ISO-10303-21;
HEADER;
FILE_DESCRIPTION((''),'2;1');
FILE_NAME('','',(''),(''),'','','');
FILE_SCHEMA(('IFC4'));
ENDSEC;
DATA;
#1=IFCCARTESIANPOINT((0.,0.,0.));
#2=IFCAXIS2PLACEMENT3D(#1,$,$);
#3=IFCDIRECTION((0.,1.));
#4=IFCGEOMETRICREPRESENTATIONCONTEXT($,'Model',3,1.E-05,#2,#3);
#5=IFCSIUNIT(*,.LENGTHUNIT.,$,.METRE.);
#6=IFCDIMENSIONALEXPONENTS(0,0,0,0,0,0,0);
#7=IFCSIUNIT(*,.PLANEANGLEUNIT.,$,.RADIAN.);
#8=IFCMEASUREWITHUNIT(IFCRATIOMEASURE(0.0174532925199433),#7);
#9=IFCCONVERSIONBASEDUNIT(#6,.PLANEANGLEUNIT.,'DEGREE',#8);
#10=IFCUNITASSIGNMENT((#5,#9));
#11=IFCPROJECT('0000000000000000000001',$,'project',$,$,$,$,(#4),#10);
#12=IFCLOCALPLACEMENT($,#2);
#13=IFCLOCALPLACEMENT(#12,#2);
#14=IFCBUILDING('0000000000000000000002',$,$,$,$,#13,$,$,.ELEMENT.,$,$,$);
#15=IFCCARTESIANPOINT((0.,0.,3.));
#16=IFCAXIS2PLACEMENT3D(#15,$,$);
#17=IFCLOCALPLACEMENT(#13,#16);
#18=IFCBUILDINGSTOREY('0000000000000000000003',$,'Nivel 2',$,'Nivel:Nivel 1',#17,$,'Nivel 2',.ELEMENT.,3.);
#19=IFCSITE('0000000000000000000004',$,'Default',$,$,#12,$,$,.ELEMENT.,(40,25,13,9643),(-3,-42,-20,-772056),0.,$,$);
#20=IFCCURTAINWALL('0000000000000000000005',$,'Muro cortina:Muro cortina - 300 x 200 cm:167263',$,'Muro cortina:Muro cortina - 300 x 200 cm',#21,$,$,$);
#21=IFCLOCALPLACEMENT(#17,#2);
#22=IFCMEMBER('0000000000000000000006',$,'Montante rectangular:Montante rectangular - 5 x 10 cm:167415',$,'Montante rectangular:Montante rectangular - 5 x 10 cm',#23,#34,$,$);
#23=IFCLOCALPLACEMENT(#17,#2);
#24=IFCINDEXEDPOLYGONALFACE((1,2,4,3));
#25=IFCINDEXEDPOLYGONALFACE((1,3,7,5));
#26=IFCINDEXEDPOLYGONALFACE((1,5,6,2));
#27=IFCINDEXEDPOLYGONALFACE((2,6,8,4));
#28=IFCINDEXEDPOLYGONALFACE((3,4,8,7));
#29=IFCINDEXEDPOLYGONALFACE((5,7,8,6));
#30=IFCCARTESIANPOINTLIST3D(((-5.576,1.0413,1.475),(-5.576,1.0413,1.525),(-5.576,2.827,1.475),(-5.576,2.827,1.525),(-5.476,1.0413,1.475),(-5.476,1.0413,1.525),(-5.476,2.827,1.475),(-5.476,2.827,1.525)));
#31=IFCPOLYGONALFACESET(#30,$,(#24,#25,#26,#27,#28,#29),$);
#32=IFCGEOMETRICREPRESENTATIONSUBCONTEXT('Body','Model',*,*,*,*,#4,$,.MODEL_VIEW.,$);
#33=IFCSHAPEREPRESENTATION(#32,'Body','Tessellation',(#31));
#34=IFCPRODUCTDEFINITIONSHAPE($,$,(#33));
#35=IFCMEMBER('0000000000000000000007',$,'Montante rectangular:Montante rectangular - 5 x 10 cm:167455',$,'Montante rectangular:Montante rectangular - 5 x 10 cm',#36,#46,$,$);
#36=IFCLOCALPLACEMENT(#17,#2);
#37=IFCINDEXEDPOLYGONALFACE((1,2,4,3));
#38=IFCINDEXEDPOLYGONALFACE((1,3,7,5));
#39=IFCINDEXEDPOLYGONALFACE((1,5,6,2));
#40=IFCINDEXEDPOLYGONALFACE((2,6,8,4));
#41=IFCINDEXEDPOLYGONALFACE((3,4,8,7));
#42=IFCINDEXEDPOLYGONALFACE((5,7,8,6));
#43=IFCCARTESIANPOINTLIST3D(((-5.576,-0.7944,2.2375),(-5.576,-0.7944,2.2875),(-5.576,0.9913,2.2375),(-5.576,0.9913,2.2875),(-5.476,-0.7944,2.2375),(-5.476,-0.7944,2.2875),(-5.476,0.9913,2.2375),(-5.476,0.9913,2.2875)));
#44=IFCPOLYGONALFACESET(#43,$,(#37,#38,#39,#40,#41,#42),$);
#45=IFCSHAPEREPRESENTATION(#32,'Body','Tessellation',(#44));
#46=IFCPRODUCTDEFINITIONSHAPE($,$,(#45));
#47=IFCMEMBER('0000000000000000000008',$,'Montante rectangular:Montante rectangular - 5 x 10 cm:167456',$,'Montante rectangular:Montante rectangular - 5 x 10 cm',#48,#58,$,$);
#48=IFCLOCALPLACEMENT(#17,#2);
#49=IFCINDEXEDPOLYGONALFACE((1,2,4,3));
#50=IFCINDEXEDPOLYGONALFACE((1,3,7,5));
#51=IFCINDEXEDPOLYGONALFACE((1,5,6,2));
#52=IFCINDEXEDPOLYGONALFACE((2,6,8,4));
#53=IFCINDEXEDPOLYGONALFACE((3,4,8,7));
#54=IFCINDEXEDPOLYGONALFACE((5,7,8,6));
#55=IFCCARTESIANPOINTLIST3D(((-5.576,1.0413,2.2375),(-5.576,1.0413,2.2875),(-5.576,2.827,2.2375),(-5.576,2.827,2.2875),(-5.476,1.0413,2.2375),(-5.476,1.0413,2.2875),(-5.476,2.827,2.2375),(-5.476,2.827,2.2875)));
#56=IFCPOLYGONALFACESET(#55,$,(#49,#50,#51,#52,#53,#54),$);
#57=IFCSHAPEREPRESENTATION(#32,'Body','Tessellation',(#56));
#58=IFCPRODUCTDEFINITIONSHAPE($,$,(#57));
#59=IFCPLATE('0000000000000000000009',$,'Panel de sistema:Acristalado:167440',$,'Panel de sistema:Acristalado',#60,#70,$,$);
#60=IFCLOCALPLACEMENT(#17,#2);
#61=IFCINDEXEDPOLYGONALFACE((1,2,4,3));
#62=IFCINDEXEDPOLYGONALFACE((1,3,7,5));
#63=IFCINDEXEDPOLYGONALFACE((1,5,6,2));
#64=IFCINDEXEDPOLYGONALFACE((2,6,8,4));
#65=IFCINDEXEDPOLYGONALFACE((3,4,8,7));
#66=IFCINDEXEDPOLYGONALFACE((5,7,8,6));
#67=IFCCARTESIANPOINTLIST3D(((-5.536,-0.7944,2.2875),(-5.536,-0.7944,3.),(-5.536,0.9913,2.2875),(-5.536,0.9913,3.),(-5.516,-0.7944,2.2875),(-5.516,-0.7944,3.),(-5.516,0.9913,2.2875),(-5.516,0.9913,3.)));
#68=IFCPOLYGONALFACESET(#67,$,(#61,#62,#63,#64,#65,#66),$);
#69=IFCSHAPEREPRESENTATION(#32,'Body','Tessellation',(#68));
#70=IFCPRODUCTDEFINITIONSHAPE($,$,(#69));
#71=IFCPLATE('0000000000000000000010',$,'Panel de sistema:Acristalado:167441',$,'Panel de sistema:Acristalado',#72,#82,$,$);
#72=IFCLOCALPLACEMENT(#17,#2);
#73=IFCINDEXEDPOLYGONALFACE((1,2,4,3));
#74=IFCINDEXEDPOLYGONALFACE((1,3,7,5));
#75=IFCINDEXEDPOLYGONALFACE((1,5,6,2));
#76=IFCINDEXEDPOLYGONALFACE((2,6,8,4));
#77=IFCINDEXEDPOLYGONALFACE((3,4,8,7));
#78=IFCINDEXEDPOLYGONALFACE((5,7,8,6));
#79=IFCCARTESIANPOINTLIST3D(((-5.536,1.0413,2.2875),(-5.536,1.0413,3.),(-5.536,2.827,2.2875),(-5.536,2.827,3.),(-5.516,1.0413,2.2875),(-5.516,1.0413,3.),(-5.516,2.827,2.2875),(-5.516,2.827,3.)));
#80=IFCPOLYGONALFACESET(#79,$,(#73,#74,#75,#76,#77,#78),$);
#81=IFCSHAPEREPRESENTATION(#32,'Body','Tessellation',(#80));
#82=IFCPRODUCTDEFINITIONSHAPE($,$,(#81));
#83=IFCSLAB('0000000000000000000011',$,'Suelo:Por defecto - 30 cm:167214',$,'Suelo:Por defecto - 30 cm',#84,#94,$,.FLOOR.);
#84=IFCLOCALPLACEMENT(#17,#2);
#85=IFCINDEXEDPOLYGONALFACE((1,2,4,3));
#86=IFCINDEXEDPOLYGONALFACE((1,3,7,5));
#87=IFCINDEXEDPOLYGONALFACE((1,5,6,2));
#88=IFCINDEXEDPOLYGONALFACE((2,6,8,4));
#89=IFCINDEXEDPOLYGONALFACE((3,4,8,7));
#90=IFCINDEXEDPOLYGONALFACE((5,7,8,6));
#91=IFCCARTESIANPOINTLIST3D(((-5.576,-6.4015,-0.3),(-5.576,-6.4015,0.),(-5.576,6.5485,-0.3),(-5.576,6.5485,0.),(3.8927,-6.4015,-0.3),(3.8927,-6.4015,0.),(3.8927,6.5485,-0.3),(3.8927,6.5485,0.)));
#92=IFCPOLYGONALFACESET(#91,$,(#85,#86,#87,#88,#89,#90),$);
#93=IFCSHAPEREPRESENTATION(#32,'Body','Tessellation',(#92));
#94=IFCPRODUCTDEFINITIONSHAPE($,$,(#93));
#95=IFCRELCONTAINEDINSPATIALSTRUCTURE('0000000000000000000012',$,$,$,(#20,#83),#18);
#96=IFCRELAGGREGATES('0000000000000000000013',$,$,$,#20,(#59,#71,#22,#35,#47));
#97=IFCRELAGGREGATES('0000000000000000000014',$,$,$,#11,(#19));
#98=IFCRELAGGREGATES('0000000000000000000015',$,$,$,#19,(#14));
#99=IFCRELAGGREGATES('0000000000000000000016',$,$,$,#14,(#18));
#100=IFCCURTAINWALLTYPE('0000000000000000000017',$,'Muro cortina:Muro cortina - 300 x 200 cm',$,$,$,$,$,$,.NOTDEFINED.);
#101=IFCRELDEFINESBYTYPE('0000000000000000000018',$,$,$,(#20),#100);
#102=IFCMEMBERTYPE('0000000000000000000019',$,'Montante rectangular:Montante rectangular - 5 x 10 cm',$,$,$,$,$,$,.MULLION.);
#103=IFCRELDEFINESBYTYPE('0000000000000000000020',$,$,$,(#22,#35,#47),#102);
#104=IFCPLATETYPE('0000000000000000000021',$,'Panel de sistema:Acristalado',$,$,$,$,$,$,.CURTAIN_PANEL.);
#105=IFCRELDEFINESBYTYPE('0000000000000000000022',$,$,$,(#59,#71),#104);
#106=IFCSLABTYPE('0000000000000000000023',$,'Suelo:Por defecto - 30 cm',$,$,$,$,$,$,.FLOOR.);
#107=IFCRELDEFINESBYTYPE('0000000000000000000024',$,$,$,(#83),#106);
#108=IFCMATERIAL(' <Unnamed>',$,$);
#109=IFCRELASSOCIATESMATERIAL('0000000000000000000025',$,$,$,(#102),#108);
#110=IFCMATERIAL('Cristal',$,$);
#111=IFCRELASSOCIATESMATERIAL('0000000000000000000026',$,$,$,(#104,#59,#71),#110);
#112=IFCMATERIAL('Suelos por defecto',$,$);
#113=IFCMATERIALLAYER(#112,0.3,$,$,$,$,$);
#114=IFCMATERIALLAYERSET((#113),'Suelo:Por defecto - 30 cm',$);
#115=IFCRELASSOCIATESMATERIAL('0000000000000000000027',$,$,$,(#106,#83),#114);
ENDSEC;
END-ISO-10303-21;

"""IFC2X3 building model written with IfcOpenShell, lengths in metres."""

from ifc_helpers import new_model, entity, si_unit, converted_unit, direction, frame, origin, origin_2d_with_axis, place, context, subcontext, project, spatial, rectangle, extrude, source, transform, mapped, material, layer, layer_set, layer_usage, type_object, type_shapes, element, aggregate, save


model = new_model("IFC2X3")

# Units and contexts
model_context = context("Model", 3, precision=1e-05, world=origin(), true_north=direction((0.0, 1.0)))
body_context = subcontext(model_context, "Body", "Model", "MODEL_VIEW")
ifc_project = project(units=[si_unit("LENGTHUNIT", "METRE"), converted_unit("PLANEANGLEUNIT", "DEGREE", entity("IfcRatioMeasure", 0.0174532925199433), si_unit("PLANEANGLEUNIT", "RADIAN"), dimensions=[0, 0, 0, 0, 0, 0, 0])], contexts=[model_context])

# Site, building, storey
site_placement = place(None, origin())
site = spatial("IfcSite", under=ifc_project, at=site_placement, Name="Default", CompositionType="ELEMENT", RefLatitude=(40, 25, 13, 9643), RefLongitude=(-3, -42, -20, -772056), RefElevation=0.0)
building_placement = place(site_placement, origin())
building = spatial("IfcBuilding", under=site, at=building_placement, CompositionType="ELEMENT")
storey_placement = place(building_placement, frame((0.0, 0.0, 3.0)))
storey = spatial("IfcBuildingStorey", under=building, at=storey_placement, Name="Nivel 2", ObjectType="Nivel:Nivel 1", LongName="Nivel 2", CompositionType="ELEMENT", Elevation=3.0)

# Curtain wall, members, plates
curtain_wall_type = type_object("IfcCurtainWallType", Name="Muro cortina:Muro cortina - 300 x 200 cm", PredefinedType="NOTDEFINED")
curtain_wall_placement = place(storey_placement, frame((0.0, 0.0, -3.0)))
curtain_wall = element("IfcCurtainWall", 1, at=curtain_wall_placement, inside=storey, type_object=curtain_wall_type, Name="Muro cortina:Muro cortina - 300 x 200 cm:167263", ObjectType="Muro cortina:Muro cortina - 300 x 200 cm")
ifc_material_1 = material(Name=" <Unnamed>")
member_type_1 = type_object("IfcMemberType", Name="Montante rectangular:Montante rectangular - 5 x 10 cm", PredefinedType="MULLION", material=ifc_material_1)
shared_shape_1 = source(origin(), body_context, "Body", "SweptSolid", [
    extrude(rectangle(XDim=0.1, YDim=0.05, at=origin_2d_with_axis()), frame((0.0, 0.0, -1.7857), z_axis=(0.0, 0.0, 1.0), x_axis=(0.0, -1.0, 0.0)), (0.0, 0.0, 1.0), 1.7857),
])
type_shapes(member_type_1, [shared_shape_1])
member_1_placement = place(storey_placement, frame((-5.526, 2.827, 1.5), z_axis=(0.0, 1.0, 0.0), x_axis=(0.0, 0.0, 1.0)))
member_1 = element("IfcMember", 2, at=member_1_placement, type_object=member_type_1, Name="Montante rectangular:Montante rectangular - 5 x 10 cm:167415", ObjectType="Montante rectangular:Montante rectangular - 5 x 10 cm", context=body_context, shape_type="MappedRepresentation", body=[
    mapped(shared_shape_1, transform((0.0, 0.0, 0.0), scale=1.0)),
])
member_2_placement = place(storey_placement, frame((-5.526, 0.9913, 2.2625), z_axis=(0.0, 1.0, 0.0), x_axis=(0.0, 0.0, 1.0)))
member_2 = element("IfcMember", 3, at=member_2_placement, type_object=member_type_1, Name="Montante rectangular:Montante rectangular - 5 x 10 cm:167455", ObjectType="Montante rectangular:Montante rectangular - 5 x 10 cm", context=body_context, shape_type="MappedRepresentation", body=[
    mapped(shared_shape_1, transform((0.0, 0.0, 0.0), scale=1.0)),
])
member_3_placement = place(storey_placement, frame((-5.526, 2.827, 2.2625), z_axis=(0.0, 1.0, 0.0), x_axis=(0.0, 0.0, 1.0)))
member_3 = element("IfcMember", 4, at=member_3_placement, type_object=member_type_1, Name="Montante rectangular:Montante rectangular - 5 x 10 cm:167456", ObjectType="Montante rectangular:Montante rectangular - 5 x 10 cm", context=body_context, shape_type="MappedRepresentation", body=[
    mapped(shared_shape_1, transform((0.0, 0.0, 0.0), scale=1.0)),
])
ifc_material_2 = material(Name="Cristal")
plate_type = type_object("IfcPlateType", Name="Panel de sistema:Acristalado", PredefinedType="CURTAIN_PANEL", material=ifc_material_2)
shared_shape_2 = source(origin(), body_context, "Body", "SweptSolid", [
    extrude(rectangle(XDim=0.02, YDim=1.7857, at=origin_2d_with_axis()), frame((0.0, 0.0, 0.0), z_axis=(0.0, 0.0, 1.0), x_axis=(0.0, 1.0, 0.0)), (0.0, 0.0, 1.0), 0.7125),
])
type_shapes(plate_type, [shared_shape_2])
plate_1_placement = place(curtain_wall_placement, frame((-5.526, 0.0985, 5.2875), z_axis=(0.0, 0.0, 1.0), x_axis=(0.0, 1.0, 0.0)))
plate_1 = element("IfcPlate", 5, at=plate_1_placement, type_object=plate_type, material=ifc_material_2, Name="Panel de sistema:Acristalado:167440", ObjectType="Panel de sistema:Acristalado", context=body_context, shape_type="MappedRepresentation", body=[
    mapped(shared_shape_2, transform((0.0, 0.0, 0.0), scale=1.0)),
])
plate_2_placement = place(curtain_wall_placement, frame((-5.526, 1.9342, 5.2875), z_axis=(0.0, 0.0, 1.0), x_axis=(0.0, 1.0, 0.0)))
plate_2 = element("IfcPlate", 6, at=plate_2_placement, type_object=plate_type, material=ifc_material_2, Name="Panel de sistema:Acristalado:167441", ObjectType="Panel de sistema:Acristalado", context=body_context, shape_type="MappedRepresentation", body=[
    mapped(shared_shape_2, transform((0.0, 0.0, 0.0), scale=1.0)),
])
aggregate(curtain_wall, [plate_1, plate_2, member_1, member_2, member_3])

# Slab
ifc_material_3 = material(Name="Suelos por defecto")
ifc_layer = layer(ifc_material_3, 0.3)
ifc_layer_set = layer_set([ifc_layer], Name="Suelo:Por defecto - 30 cm")
ifc_layer_usage = layer_usage(ifc_layer_set, "AXIS3", "POSITIVE", 0.0)
slab_type = type_object("IfcSlabType", Name="Suelo:Por defecto - 30 cm", PredefinedType="FLOOR", material=ifc_layer_set)
slab_placement = place(storey_placement, origin())
element("IfcSlab", 7, at=slab_placement, inside=storey, type_object=slab_type, material=ifc_layer_usage, Name="Suelo:Por defecto - 30 cm:167214", ObjectType="Suelo:Por defecto - 30 cm", PredefinedType="FLOOR", context=body_context, shape_type="SweptSolid", body=[
    extrude(rectangle(XDim=12.95, YDim=9.4687, at=origin_2d_with_axis()), frame((-0.8416, 0.0735, 0.0), z_axis=(0.0, 0.0, -1.0), x_axis=(0.0, 1.0, 0.0)), (0.0, 0.0, 1.0), 0.3),
])

save(model, "model.ifc")
